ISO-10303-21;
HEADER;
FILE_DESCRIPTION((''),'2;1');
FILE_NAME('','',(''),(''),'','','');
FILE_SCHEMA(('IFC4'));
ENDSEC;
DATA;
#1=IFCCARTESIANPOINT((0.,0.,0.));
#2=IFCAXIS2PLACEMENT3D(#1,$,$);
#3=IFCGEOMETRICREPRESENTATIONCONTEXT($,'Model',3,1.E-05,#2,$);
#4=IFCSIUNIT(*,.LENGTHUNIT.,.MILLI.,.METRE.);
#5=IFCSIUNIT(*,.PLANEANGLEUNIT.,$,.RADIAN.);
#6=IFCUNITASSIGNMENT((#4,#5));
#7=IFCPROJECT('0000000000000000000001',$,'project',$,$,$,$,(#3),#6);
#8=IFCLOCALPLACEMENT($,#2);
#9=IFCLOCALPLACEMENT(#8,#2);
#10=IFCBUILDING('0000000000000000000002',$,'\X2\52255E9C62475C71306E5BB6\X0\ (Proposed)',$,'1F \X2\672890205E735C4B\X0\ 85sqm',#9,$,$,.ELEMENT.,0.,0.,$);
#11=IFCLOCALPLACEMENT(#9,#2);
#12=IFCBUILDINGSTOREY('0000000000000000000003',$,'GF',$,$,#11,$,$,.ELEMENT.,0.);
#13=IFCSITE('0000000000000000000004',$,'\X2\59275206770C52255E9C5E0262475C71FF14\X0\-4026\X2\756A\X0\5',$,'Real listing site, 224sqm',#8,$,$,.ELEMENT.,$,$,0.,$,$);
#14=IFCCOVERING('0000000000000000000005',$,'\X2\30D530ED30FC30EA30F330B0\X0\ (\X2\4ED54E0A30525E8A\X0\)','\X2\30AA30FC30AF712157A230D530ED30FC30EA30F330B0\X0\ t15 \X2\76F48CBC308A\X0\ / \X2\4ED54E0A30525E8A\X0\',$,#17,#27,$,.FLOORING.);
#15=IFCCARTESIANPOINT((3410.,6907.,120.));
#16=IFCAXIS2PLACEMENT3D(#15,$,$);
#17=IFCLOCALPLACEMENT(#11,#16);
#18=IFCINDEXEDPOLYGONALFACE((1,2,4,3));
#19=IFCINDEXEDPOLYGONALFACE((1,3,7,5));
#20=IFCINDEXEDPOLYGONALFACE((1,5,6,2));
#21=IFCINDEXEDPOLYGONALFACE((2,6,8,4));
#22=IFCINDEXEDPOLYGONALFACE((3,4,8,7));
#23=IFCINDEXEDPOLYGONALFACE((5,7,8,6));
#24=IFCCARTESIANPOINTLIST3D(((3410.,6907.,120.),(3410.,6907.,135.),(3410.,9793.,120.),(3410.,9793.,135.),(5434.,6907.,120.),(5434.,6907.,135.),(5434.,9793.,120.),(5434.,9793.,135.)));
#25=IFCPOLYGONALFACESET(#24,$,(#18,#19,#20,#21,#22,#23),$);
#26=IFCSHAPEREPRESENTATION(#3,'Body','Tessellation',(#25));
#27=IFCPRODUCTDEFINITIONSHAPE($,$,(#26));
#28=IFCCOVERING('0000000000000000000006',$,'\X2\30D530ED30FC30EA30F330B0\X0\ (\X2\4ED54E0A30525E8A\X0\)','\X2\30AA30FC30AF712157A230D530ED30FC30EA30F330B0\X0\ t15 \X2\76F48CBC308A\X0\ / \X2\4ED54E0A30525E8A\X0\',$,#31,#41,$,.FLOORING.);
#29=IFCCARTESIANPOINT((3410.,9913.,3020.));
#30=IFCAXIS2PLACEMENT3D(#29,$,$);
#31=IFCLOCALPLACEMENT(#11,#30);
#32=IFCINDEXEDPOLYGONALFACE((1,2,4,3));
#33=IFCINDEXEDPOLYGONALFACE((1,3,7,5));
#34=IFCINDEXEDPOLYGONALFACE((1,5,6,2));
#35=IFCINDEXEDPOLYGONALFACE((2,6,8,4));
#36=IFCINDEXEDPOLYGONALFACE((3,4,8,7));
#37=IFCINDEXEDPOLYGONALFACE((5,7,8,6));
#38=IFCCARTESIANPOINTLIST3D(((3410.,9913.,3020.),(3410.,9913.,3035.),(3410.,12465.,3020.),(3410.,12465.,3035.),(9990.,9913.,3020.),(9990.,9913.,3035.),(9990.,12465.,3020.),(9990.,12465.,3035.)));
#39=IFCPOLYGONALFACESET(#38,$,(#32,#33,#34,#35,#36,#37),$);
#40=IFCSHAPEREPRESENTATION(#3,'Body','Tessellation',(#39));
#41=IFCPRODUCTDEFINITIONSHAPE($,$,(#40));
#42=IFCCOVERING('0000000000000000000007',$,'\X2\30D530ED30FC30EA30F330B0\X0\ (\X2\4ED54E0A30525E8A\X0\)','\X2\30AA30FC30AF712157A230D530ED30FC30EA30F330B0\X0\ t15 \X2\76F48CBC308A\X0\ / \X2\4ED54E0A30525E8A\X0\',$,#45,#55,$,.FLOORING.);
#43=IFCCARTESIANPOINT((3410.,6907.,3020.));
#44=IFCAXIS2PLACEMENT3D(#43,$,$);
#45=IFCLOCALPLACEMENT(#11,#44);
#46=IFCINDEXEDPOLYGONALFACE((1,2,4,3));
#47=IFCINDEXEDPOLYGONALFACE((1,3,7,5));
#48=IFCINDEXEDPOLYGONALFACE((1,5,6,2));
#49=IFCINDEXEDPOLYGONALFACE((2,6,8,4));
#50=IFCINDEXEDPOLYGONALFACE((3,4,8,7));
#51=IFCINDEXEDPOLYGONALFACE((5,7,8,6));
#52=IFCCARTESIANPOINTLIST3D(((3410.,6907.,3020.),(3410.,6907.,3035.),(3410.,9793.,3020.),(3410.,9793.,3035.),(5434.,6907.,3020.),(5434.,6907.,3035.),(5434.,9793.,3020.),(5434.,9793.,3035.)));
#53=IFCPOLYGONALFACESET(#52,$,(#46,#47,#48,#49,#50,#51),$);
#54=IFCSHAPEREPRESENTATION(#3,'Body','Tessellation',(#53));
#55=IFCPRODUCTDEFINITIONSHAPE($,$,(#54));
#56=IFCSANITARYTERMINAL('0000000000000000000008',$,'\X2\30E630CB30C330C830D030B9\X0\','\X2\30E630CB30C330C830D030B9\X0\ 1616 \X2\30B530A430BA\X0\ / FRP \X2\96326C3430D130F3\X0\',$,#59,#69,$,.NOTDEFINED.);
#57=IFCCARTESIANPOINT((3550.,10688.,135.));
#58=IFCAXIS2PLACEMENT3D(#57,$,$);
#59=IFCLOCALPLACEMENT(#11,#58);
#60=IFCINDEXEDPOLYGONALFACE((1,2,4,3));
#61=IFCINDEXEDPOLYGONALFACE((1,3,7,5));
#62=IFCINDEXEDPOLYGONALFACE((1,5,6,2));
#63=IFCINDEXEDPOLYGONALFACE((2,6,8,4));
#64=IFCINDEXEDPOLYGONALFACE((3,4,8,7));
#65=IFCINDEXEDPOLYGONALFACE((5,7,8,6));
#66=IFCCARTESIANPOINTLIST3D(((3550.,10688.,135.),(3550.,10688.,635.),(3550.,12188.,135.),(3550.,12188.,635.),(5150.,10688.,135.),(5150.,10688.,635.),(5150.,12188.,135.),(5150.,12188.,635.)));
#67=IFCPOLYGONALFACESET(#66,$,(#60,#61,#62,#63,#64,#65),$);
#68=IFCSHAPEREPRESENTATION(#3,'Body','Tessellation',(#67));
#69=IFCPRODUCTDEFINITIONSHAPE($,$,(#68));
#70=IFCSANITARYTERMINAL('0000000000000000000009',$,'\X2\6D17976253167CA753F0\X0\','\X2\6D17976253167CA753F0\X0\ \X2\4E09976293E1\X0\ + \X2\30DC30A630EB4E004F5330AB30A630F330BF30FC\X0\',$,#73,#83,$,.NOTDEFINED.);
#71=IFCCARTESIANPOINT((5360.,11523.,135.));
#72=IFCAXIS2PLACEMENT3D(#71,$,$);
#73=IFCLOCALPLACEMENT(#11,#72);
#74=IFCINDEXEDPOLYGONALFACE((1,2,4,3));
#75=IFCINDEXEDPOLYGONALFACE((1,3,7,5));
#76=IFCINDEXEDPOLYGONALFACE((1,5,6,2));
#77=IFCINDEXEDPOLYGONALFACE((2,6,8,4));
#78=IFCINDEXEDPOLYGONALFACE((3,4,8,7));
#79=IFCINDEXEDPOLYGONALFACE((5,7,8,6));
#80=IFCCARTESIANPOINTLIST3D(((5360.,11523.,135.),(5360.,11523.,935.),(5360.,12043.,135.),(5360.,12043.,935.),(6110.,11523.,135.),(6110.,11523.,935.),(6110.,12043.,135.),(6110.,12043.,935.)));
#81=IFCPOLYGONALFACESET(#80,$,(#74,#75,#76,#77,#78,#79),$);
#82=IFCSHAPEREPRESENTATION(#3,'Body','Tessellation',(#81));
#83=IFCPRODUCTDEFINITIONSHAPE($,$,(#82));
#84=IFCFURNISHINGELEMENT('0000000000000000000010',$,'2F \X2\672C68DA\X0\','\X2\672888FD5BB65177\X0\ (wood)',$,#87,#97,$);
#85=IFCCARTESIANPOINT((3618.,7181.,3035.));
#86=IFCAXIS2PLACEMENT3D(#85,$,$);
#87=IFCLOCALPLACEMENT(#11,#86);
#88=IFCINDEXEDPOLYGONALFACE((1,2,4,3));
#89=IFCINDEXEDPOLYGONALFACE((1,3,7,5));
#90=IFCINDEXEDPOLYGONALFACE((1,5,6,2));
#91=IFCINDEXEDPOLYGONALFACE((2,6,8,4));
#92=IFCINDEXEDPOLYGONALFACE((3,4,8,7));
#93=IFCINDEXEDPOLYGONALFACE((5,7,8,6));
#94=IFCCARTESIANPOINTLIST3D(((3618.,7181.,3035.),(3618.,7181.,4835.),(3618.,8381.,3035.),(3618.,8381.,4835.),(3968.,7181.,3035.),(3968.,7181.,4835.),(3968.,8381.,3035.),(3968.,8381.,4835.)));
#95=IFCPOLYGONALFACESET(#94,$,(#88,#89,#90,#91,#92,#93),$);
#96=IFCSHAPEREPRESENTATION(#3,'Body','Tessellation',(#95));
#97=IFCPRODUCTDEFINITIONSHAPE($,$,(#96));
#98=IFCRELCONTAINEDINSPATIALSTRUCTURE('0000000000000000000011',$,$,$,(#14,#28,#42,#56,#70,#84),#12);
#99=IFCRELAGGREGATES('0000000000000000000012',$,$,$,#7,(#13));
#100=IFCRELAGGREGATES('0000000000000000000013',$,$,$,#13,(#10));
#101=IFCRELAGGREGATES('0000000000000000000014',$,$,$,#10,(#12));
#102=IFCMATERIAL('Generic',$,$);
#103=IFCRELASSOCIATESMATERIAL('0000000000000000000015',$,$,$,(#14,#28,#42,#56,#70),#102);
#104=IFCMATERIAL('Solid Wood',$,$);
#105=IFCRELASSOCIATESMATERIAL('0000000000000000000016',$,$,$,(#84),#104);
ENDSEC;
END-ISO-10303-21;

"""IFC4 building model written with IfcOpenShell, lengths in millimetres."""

from ifc_helpers import new_model, si_unit, frame, frame_2d, origin, place, context, project, spatial, rectangle, extrude, material, element, save


model = new_model("IFC4")

# Units and contexts
model_context = context("Model", 3, precision=1e-05, world=origin())
ifc_project = project(units=[si_unit("LENGTHUNIT", "METRE", prefix="MILLI"), si_unit("PLANEANGLEUNIT", "RADIAN")], contexts=[model_context])

# Site, building, storey
site_placement = place(None, origin())
site = spatial("IfcSite", under=ifc_project, at=site_placement, Name="大分県別府市扇山４-4026番5", ObjectType="Real listing site, 224sqm", CompositionType="ELEMENT", RefElevation=0.0)
building_placement = place(site_placement, origin())
building = spatial("IfcBuilding", under=site, at=building_placement, Name="別府扇山の家 (Proposed)", ObjectType="1F 木造平屋 85sqm", CompositionType="ELEMENT", ElevationOfRefHeight=0.0, ElevationOfTerrain=0.0)
storey_placement = place(building_placement, origin())
storey = spatial("IfcBuildingStorey", under=building, at=storey_placement, Name="GF", CompositionType="ELEMENT", Elevation=0.0)

# Shared definitions
ifc_material_1 = material(Name="Solid Wood")

# Coverings
ifc_material_2 = material(Name="Generic")
covering_1_placement = place(storey_placement, frame((3410.0, 6907.0, 120.0)))
element("IfcCovering", 1, at=covering_1_placement, inside=storey, material=ifc_material_2, Name="フローリング (仕上げ床)", Description="オーク無垢フローリング t15 直貼り / 仕上げ床", PredefinedType="FLOORING", context=model_context, shape_type="SweptSolid", body=[
    extrude(rectangle(XDim=2024.0, YDim=2886.0, at=frame_2d((1012.0, 1443.0))), frame((3410.0, 6907.0, 120.0)), (0.0, 0.0, 1.0), 15.0),
])
covering_2_placement = place(storey_placement, frame((3410.0, 9913.0, 3020.0)))
element("IfcCovering", 2, at=covering_2_placement, inside=storey, material=ifc_material_2, Name="フローリング (仕上げ床)", Description="オーク無垢フローリング t15 直貼り / 仕上げ床", PredefinedType="FLOORING", context=model_context, shape_type="SweptSolid", body=[
    extrude(rectangle(XDim=6580.0, YDim=2552.0, at=frame_2d((3290.0, 1276.0))), frame((3410.0, 9913.0, 3020.0)), (0.0, 0.0, 1.0), 15.0),
])
covering_3_placement = place(storey_placement, frame((3410.0, 6907.0, 3020.0)))
element("IfcCovering", 3, at=covering_3_placement, inside=storey, material=ifc_material_2, Name="フローリング (仕上げ床)", Description="オーク無垢フローリング t15 直貼り / 仕上げ床", PredefinedType="FLOORING", context=model_context, shape_type="SweptSolid", body=[
    extrude(rectangle(XDim=2024.0, YDim=2886.0, at=frame_2d((1012.0, 1443.0))), frame((3410.0, 6907.0, 3020.0)), (0.0, 0.0, 1.0), 15.0),
])

# Sanitary terminals
sanitary_terminal_1_placement = place(storey_placement, frame((3550.0, 10688.0, 135.0)))
element("IfcSanitaryTerminal", 4, at=sanitary_terminal_1_placement, inside=storey, material=ifc_material_2, Name="ユニットバス", Description="ユニットバス 1616 サイズ / FRP 防水パン", PredefinedType="NOTDEFINED", context=model_context, shape_type="SweptSolid", body=[
    extrude(rectangle(XDim=1600.0, YDim=1500.0, at=frame_2d((800.0, 750.0))), frame((3550.0, 10688.0, 135.0)), (0.0, 0.0, 1.0), 500.0),
])
sanitary_terminal_2_placement = place(storey_placement, frame((5360.0, 11523.0, 135.0)))
element("IfcSanitaryTerminal", 5, at=sanitary_terminal_2_placement, inside=storey, material=ifc_material_2, Name="洗面化粧台", Description="洗面化粧台 三面鏡 + ボウル一体カウンター", PredefinedType="NOTDEFINED", context=model_context, shape_type="SweptSolid", body=[
    extrude(rectangle(XDim=750.0, YDim=520.0, at=frame_2d((375.0, 260.0))), frame((5360.0, 11523.0, 135.0)), (0.0, 0.0, 1.0), 800.0),
])

# Furnishing element
furnishing_placement = place(storey_placement, frame((3618.0, 7181.0, 3035.0)))
element("IfcFurnishingElement", 6, at=furnishing_placement, inside=storey, material=ifc_material_1, Name="2F 本棚", Description="木製家具 (wood)", context=model_context, shape_type="SweptSolid", body=[
    extrude(rectangle(XDim=350.0, YDim=1200.0, at=frame_2d((175.0, 600.0))), frame((3618.0, 7181.0, 3035.0)), (0.0, 0.0, 1.0), 1800.0),
])

save(model, "model.ifc")
